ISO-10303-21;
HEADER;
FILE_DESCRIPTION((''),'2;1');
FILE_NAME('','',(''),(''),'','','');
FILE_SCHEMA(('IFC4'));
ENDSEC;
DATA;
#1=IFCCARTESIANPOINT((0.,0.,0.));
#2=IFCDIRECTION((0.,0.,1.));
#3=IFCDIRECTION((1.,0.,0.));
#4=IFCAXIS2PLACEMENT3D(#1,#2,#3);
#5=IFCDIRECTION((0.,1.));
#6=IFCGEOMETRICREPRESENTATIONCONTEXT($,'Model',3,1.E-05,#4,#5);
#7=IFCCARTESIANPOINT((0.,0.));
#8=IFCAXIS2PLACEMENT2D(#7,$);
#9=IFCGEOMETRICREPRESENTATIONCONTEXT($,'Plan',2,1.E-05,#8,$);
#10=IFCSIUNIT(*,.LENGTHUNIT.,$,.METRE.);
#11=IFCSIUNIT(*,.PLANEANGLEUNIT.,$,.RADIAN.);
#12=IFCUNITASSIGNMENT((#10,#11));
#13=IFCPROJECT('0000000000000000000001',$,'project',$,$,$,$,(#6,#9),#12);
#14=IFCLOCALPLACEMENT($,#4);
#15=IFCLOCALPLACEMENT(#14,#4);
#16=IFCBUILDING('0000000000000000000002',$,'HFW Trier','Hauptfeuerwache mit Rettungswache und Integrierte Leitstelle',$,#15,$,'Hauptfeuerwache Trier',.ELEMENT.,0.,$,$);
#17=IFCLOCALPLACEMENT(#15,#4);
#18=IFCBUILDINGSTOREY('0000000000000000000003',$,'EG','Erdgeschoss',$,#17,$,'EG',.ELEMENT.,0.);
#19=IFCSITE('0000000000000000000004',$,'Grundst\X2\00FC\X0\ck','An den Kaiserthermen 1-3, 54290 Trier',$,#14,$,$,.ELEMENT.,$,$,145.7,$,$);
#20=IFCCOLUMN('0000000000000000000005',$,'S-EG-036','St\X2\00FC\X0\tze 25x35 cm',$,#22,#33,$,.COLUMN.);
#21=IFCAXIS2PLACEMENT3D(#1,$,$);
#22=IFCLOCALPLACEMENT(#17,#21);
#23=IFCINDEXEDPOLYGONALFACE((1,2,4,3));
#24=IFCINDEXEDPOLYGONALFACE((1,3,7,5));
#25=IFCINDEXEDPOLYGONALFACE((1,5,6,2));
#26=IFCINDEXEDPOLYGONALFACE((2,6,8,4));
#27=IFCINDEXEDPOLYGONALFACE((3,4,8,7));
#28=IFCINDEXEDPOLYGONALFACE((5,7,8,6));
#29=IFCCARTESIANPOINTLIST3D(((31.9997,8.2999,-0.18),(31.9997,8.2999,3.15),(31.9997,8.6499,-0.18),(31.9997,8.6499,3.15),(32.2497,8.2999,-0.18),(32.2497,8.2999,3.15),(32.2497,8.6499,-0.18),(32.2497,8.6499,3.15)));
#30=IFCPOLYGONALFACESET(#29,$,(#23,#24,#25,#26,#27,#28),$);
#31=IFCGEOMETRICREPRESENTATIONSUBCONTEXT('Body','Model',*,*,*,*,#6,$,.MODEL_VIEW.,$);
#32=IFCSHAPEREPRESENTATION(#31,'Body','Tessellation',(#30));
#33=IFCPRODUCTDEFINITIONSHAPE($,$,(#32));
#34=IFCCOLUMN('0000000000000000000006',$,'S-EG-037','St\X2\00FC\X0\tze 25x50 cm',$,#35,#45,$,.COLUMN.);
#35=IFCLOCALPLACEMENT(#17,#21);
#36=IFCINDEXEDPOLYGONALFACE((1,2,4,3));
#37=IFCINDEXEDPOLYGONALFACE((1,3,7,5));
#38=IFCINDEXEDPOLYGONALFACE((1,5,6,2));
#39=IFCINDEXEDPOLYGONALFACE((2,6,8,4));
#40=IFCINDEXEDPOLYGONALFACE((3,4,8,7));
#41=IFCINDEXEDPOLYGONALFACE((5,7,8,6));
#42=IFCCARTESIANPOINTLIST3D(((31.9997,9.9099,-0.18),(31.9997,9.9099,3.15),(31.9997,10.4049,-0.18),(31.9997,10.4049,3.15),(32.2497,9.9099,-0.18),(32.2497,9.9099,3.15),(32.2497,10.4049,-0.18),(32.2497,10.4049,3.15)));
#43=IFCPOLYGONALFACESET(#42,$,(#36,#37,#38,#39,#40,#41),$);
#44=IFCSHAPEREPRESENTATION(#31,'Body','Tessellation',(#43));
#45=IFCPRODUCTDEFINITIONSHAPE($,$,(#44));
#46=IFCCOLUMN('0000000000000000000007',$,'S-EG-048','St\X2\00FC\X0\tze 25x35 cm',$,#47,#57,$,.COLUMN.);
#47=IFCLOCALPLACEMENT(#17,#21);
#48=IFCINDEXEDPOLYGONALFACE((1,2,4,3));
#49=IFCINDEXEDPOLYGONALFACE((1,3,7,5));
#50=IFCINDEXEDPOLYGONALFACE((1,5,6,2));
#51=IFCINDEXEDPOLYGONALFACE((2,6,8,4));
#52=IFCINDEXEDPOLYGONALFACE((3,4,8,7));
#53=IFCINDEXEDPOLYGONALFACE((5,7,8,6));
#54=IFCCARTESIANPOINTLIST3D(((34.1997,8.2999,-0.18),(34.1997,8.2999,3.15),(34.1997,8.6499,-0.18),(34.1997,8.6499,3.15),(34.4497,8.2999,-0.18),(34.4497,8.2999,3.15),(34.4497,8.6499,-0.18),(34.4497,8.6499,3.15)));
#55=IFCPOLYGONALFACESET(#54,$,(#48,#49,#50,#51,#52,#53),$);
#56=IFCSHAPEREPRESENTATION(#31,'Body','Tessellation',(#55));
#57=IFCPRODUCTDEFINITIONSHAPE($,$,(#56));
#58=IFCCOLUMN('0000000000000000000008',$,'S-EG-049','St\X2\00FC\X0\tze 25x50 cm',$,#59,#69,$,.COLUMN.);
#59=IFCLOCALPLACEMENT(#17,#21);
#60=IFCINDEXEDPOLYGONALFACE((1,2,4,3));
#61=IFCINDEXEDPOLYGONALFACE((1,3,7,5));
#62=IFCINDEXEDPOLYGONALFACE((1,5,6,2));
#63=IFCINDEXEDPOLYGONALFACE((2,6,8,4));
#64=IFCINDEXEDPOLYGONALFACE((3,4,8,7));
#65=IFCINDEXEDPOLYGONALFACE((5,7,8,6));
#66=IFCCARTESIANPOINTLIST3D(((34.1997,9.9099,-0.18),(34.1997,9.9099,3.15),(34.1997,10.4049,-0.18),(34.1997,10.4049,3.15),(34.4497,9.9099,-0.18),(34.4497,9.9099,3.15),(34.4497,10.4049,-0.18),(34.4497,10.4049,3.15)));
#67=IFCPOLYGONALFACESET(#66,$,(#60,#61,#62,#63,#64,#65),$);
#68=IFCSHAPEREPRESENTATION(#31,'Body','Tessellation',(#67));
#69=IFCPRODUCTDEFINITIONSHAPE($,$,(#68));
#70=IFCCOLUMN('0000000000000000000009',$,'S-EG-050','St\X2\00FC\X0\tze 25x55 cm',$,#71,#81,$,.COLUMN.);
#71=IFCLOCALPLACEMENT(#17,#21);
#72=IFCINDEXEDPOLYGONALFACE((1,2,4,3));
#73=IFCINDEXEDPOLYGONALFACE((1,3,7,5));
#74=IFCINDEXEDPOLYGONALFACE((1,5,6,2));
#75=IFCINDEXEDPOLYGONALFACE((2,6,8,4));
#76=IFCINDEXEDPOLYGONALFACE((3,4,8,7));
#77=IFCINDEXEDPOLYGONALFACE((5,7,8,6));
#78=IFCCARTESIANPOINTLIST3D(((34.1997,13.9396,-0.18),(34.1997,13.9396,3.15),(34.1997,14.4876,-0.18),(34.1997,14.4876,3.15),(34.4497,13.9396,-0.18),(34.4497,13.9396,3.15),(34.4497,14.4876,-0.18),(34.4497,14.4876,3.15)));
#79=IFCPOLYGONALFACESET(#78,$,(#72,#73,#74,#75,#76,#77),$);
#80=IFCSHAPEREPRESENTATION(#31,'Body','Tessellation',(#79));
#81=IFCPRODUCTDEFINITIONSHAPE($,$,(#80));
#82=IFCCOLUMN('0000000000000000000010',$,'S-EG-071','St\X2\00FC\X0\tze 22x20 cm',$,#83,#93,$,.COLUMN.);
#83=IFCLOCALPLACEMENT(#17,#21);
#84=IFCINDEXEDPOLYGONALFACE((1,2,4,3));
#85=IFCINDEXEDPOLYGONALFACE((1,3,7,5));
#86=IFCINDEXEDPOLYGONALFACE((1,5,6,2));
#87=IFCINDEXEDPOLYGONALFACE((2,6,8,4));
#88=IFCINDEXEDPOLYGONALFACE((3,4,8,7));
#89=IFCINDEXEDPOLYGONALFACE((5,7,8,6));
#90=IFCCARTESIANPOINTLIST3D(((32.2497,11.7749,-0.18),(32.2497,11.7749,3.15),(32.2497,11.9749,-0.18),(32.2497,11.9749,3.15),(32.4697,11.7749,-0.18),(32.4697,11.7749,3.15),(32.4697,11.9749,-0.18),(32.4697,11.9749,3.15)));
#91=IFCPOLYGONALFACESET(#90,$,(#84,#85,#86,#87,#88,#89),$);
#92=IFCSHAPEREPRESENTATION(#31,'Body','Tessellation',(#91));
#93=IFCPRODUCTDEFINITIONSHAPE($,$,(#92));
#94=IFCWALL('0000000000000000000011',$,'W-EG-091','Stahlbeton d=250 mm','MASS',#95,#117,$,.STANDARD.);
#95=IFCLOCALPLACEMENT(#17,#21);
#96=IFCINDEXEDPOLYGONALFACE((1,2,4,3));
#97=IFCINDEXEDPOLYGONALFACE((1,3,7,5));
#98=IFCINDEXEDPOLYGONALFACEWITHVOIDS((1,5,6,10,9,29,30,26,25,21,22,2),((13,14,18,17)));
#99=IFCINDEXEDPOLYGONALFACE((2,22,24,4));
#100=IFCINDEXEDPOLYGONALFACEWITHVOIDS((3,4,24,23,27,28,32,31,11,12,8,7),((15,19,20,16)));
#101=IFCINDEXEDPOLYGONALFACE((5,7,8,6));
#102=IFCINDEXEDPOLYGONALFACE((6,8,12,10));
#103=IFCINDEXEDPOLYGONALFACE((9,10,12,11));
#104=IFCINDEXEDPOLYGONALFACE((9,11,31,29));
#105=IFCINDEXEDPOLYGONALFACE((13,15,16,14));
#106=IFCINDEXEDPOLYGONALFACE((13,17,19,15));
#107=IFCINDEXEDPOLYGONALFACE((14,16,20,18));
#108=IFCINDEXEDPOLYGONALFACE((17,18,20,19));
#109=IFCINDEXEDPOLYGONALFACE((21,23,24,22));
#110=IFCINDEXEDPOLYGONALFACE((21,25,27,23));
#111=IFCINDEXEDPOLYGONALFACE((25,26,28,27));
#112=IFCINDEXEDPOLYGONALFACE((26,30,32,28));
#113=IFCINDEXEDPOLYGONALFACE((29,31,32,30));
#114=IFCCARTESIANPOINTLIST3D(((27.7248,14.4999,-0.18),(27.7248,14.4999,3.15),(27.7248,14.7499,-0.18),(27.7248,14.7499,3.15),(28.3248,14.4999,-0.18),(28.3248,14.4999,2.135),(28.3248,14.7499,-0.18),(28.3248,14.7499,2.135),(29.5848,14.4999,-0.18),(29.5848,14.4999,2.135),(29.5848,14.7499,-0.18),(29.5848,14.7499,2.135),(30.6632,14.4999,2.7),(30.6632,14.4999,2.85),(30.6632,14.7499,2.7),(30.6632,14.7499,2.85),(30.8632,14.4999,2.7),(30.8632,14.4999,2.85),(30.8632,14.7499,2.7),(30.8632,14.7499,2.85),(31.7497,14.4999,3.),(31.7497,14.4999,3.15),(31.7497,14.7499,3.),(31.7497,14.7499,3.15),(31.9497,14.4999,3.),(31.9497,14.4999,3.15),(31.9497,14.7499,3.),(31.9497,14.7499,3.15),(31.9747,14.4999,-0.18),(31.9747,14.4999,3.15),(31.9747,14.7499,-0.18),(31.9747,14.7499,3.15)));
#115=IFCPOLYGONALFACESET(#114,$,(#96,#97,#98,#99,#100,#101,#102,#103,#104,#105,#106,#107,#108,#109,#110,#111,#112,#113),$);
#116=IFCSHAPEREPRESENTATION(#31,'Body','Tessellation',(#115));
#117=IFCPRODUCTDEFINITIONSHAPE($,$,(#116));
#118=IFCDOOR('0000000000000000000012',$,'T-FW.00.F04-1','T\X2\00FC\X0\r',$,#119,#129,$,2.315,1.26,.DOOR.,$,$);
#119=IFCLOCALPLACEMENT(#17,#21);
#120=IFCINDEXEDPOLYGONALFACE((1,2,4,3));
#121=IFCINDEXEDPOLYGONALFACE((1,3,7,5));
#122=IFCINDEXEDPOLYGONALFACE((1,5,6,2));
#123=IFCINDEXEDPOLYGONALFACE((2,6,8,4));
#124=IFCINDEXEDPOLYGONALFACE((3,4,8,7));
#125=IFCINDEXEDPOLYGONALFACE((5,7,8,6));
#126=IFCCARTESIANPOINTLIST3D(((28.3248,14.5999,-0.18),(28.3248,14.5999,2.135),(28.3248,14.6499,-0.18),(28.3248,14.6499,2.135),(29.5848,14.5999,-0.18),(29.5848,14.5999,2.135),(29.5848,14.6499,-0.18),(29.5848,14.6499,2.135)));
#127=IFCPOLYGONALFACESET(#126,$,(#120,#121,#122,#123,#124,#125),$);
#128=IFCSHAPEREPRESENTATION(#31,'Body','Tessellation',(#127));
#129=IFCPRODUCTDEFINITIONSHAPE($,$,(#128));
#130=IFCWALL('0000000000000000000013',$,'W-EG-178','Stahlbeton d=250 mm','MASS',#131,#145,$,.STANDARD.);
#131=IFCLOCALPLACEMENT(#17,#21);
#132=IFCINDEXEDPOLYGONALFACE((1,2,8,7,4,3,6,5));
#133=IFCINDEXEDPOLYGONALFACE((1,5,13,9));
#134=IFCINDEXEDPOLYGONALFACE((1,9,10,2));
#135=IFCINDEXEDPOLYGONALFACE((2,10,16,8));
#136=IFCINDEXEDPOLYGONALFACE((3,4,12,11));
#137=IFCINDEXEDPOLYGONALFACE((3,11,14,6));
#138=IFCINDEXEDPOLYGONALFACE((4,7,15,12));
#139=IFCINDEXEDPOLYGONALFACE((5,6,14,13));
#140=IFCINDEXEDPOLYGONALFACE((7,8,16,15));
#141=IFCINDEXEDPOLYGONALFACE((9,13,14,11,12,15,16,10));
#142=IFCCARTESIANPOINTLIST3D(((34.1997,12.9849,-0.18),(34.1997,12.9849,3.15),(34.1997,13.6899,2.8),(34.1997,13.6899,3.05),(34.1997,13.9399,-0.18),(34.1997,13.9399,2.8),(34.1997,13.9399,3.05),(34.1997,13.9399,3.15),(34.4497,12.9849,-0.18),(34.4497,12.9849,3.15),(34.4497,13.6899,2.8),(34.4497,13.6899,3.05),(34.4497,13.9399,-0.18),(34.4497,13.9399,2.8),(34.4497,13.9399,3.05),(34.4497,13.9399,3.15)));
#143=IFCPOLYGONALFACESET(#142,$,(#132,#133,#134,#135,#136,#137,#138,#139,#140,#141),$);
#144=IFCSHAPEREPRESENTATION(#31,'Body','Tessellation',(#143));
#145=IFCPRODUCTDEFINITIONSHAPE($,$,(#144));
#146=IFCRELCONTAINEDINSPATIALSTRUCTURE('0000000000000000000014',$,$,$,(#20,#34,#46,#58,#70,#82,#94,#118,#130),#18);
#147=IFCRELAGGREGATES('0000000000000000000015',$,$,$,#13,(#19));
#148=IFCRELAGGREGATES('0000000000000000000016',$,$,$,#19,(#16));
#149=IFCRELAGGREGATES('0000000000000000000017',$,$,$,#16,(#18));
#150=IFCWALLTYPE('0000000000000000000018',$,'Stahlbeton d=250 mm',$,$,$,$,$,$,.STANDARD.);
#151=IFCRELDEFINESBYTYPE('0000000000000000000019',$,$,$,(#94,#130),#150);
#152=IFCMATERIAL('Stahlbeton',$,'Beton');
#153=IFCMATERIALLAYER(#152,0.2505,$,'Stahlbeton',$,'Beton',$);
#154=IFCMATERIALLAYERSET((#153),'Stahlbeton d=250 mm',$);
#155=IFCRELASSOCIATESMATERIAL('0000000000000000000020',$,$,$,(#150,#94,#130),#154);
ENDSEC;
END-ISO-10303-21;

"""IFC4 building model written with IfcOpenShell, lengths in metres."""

from ifc_helpers import new_model, si_unit, direction, frame, frame_2d, origin_with_axes, origin_2d, place, context, subcontext, project, spatial, rectangle, extrude, material, layer, layer_set, layer_usage, type_object, element, fill, save


model = new_model("IFC4")

# Units and contexts
model_context = context("Model", 3, precision=1e-05, world=origin_with_axes(), true_north=direction((0.0, 1.0)))
plan_context = context("Plan", 2, precision=1e-05, world=origin_2d())
body_context = subcontext(model_context, "Body", "Model", "MODEL_VIEW")
ifc_project = project(units=[si_unit("LENGTHUNIT", "METRE"), si_unit("PLANEANGLEUNIT", "RADIAN")], contexts=[model_context, plan_context])

# Site, building, storey
site_placement = place(None, origin_with_axes())
site = spatial("IfcSite", under=ifc_project, at=site_placement, Name="Grundstück", Description="An den Kaiserthermen 1-3, 54290 Trier", CompositionType="ELEMENT", RefElevation=145.7)
building_placement = place(site_placement, origin_with_axes())
building = spatial("IfcBuilding", under=site, at=building_placement, Name="HFW Trier", Description="Hauptfeuerwache mit Rettungswache und Integrierte Leitstelle", LongName="Hauptfeuerwache Trier", CompositionType="ELEMENT", ElevationOfRefHeight=0.0)
storey_placement = place(building_placement, origin_with_axes())
storey = spatial("IfcBuildingStorey", under=building, at=storey_placement, Name="EG", Description="Erdgeschoss", LongName="EG", CompositionType="ELEMENT", Elevation=0.0)

# Columns
column_1_placement = place(storey_placement, frame((31.9997, 8.4749, -0.18), z_axis=(0.0, 0.0, 1.0), x_axis=(1.0, 0.0, 0.0)))
element("IfcColumn", 1, at=column_1_placement, inside=storey, Name="S-EG-036", Description="Stütze 25x35 cm", PredefinedType="COLUMN", context=body_context, shape_type="SweptSolid", body=[
    extrude(rectangle(XDim=0.25, YDim=0.35, at=frame_2d((0.125, 0.0))), origin_with_axes(), (0.0, 0.0, 1.0), 3.33),
])
column_2_placement = place(storey_placement, frame((31.9997, 10.1574, -0.18), z_axis=(0.0, 0.0, 1.0), x_axis=(1.0, 0.0, 0.0)))
element("IfcColumn", 2, at=column_2_placement, inside=storey, Name="S-EG-037", Description="Stütze 25x50 cm", PredefinedType="COLUMN", context=body_context, shape_type="SweptSolid", body=[
    extrude(rectangle(XDim=0.25, YDim=0.495, at=frame_2d((0.125, 0.0))), origin_with_axes(), (0.0, 0.0, 1.0), 3.33),
])
column_3_placement = place(storey_placement, frame((34.1997, 8.4749, -0.18), z_axis=(0.0, 0.0, 1.0), x_axis=(1.0, 0.0, 0.0)))
element("IfcColumn", 3, at=column_3_placement, inside=storey, Name="S-EG-048", Description="Stütze 25x35 cm", PredefinedType="COLUMN", context=body_context, shape_type="SweptSolid", body=[
    extrude(rectangle(XDim=0.25, YDim=0.35, at=frame_2d((0.125, 0.0))), origin_with_axes(), (0.0, 0.0, 1.0), 3.33),
])
column_4_placement = place(storey_placement, frame((34.1997, 10.1574, -0.18), z_axis=(0.0, 0.0, 1.0), x_axis=(1.0, 0.0, 0.0)))
element("IfcColumn", 4, at=column_4_placement, inside=storey, Name="S-EG-049", Description="Stütze 25x50 cm", PredefinedType="COLUMN", context=body_context, shape_type="SweptSolid", body=[
    extrude(rectangle(XDim=0.25, YDim=0.495, at=frame_2d((0.125, 0.0))), origin_with_axes(), (0.0, 0.0, 1.0), 3.33),
])
column_5_placement = place(storey_placement, frame((34.1997, 14.2136, -0.18), z_axis=(0.0, 0.0, 1.0), x_axis=(1.0, 0.0, 0.0)))
element("IfcColumn", 5, at=column_5_placement, inside=storey, Name="S-EG-050", Description="Stütze 25x55 cm", PredefinedType="COLUMN", context=body_context, shape_type="SweptSolid", body=[
    extrude(rectangle(XDim=0.25, YDim=0.548, at=frame_2d((0.125, 0.0))), origin_with_axes(), (0.0, 0.0, 1.0), 3.33),
])
column_6_placement = place(storey_placement, frame((32.2497, 11.8749, -0.18), z_axis=(0.0, 0.0, 1.0), x_axis=(1.0, 0.0, 0.0)))
element("IfcColumn", 6, at=column_6_placement, inside=storey, Name="S-EG-071", Description="Stütze 22x20 cm", PredefinedType="COLUMN", context=body_context, shape_type="SweptSolid", body=[
    extrude(rectangle(XDim=0.22, YDim=0.2, at=frame_2d((0.11, 0.0))), origin_with_axes(), (0.0, 0.0, 1.0), 3.33),
])

# Wall, openings, door
ifc_material_1 = material(Name="Stahlbeton", Category="Beton")
ifc_layer_1 = layer(ifc_material_1, 0.2505, Name="Stahlbeton", Category="Beton")
ifc_layer_set_1 = layer_set([ifc_layer_1], Name="Stahlbeton d=250 mm")
ifc_layer_usage_1 = layer_usage(ifc_layer_set_1, "AXIS2", "POSITIVE", -0.125)
wall_type_1 = type_object("IfcWallType", Name="Stahlbeton d=250 mm", PredefinedType="STANDARD", material=ifc_layer_set_1)
wall_1_placement = place(storey_placement, frame((27.7248, 14.6249, -0.18), z_axis=(0.0, 0.0, 1.0), x_axis=(1.0, 0.0, 0.0)))
wall_1 = element("IfcWall", 7, at=wall_1_placement, inside=storey, type_object=wall_type_1, material=ifc_layer_usage_1, Name="W-EG-091", Description="Stahlbeton d=250 mm", ObjectType="MASS", PredefinedType="STANDARD", context=body_context, shape_type="SweptSolid", body=[
    extrude(rectangle(XDim=4.2499, YDim=0.25, at=frame_2d((2.125, 0.0))), origin_with_axes(), (0.0, 0.0, 1.0), 3.33),
])
opening_1_placement = place(wall_1_placement, frame((0.6, 0.0, 0.0), z_axis=(0.0, 0.0, 1.0), x_axis=(1.0, 0.0, 0.0)))
opening_1 = element("IfcOpeningElement", 8, at=opening_1_placement, cuts=wall_1, PredefinedType="OPENING", context=body_context, shape_type="SweptSolid", body=[
    extrude(rectangle(XDim=1.26, YDim=0.35, at=frame_2d((0.63, 0.0))), origin_with_axes(), (0.0, 0.0, 1.0), 2.315),
])
opening_2_placement = place(wall_1_placement, origin_with_axes())
element("IfcOpeningElement", 9, at=opening_2_placement, cuts=wall_1, ObjectType="Wanddurchbruch", PredefinedType="OPENING", context=body_context, shape_type="SweptSolid", body=[
    extrude(rectangle(XDim=0.2, YDim=0.35, at=frame_2d((4.1249, 0.0))), frame((0.0, 0.0, 3.18), z_axis=(0.0, 0.0, 1.0), x_axis=(1.0, 0.0, 0.0)), (0.0, 0.0, 1.0), 0.15),
])
opening_3_placement = place(wall_1_placement, origin_with_axes())
element("IfcOpeningElement", 10, at=opening_3_placement, cuts=wall_1, ObjectType="Wanddurchbruch", PredefinedType="OPENING", context=body_context, shape_type="SweptSolid", body=[
    extrude(rectangle(XDim=0.2, YDim=0.35, at=frame_2d((3.0384, 0.0))), frame((0.0, 0.0, 2.88), z_axis=(0.0, 0.0, 1.0), x_axis=(1.0, 0.0, 0.0)), (0.0, 0.0, 1.0), 0.15),
])
door_placement = place(wall_1_placement, frame((0.6, 0.0, 0.0), z_axis=(0.0, 0.0, 1.0), x_axis=(1.0, 0.0, 0.0)))
door = element("IfcDoor", 11, at=door_placement, inside=storey, Name="T-FW.00.F04-1", Description="Tür", OverallHeight=2.315, OverallWidth=1.26, PredefinedType="DOOR", context=body_context, shape_type="SweptSolid", body=[
    extrude(rectangle(XDim=1.26, YDim=0.05, at=frame_2d((0.63, 0.0))), origin_with_axes(), (0.0, 0.0, 1.0), 2.315),
])
fill(opening_1, door)

# Wall, opening
ifc_layer_usage_2 = layer_usage(ifc_layer_set_1, "AXIS2", "POSITIVE", -0.125)
wall_2_placement = place(storey_placement, frame((34.3247, 13.9399, -0.18), z_axis=(0.0, 0.0, 1.0), x_axis=(0.0, -1.0, 0.0)))
wall_2 = element("IfcWall", 12, at=wall_2_placement, inside=storey, type_object=wall_type_1, material=ifc_layer_usage_2, Name="W-EG-178", Description="Stahlbeton d=250 mm", ObjectType="MASS", PredefinedType="STANDARD", context=body_context, shape_type="SweptSolid", body=[
    extrude(rectangle(XDim=0.955, YDim=0.25, at=frame_2d((0.4775, 0.0))), origin_with_axes(), (0.0, 0.0, 1.0), 3.33),
])
opening_4_placement = place(wall_2_placement, origin_with_axes())
element("IfcOpeningElement", 13, at=opening_4_placement, cuts=wall_2, ObjectType="Wanddurchbruch", PredefinedType="OPENING", context=body_context, shape_type="SweptSolid", body=[
    extrude(rectangle(XDim=0.25, YDim=0.35, at=frame_2d((0.125, 0.0))), frame((0.0, 0.0, 2.98), z_axis=(0.0, 0.0, 1.0), x_axis=(1.0, 0.0, 0.0)), (0.0, 0.0, 1.0), 0.25),
])

save(model, "model.ifc")
